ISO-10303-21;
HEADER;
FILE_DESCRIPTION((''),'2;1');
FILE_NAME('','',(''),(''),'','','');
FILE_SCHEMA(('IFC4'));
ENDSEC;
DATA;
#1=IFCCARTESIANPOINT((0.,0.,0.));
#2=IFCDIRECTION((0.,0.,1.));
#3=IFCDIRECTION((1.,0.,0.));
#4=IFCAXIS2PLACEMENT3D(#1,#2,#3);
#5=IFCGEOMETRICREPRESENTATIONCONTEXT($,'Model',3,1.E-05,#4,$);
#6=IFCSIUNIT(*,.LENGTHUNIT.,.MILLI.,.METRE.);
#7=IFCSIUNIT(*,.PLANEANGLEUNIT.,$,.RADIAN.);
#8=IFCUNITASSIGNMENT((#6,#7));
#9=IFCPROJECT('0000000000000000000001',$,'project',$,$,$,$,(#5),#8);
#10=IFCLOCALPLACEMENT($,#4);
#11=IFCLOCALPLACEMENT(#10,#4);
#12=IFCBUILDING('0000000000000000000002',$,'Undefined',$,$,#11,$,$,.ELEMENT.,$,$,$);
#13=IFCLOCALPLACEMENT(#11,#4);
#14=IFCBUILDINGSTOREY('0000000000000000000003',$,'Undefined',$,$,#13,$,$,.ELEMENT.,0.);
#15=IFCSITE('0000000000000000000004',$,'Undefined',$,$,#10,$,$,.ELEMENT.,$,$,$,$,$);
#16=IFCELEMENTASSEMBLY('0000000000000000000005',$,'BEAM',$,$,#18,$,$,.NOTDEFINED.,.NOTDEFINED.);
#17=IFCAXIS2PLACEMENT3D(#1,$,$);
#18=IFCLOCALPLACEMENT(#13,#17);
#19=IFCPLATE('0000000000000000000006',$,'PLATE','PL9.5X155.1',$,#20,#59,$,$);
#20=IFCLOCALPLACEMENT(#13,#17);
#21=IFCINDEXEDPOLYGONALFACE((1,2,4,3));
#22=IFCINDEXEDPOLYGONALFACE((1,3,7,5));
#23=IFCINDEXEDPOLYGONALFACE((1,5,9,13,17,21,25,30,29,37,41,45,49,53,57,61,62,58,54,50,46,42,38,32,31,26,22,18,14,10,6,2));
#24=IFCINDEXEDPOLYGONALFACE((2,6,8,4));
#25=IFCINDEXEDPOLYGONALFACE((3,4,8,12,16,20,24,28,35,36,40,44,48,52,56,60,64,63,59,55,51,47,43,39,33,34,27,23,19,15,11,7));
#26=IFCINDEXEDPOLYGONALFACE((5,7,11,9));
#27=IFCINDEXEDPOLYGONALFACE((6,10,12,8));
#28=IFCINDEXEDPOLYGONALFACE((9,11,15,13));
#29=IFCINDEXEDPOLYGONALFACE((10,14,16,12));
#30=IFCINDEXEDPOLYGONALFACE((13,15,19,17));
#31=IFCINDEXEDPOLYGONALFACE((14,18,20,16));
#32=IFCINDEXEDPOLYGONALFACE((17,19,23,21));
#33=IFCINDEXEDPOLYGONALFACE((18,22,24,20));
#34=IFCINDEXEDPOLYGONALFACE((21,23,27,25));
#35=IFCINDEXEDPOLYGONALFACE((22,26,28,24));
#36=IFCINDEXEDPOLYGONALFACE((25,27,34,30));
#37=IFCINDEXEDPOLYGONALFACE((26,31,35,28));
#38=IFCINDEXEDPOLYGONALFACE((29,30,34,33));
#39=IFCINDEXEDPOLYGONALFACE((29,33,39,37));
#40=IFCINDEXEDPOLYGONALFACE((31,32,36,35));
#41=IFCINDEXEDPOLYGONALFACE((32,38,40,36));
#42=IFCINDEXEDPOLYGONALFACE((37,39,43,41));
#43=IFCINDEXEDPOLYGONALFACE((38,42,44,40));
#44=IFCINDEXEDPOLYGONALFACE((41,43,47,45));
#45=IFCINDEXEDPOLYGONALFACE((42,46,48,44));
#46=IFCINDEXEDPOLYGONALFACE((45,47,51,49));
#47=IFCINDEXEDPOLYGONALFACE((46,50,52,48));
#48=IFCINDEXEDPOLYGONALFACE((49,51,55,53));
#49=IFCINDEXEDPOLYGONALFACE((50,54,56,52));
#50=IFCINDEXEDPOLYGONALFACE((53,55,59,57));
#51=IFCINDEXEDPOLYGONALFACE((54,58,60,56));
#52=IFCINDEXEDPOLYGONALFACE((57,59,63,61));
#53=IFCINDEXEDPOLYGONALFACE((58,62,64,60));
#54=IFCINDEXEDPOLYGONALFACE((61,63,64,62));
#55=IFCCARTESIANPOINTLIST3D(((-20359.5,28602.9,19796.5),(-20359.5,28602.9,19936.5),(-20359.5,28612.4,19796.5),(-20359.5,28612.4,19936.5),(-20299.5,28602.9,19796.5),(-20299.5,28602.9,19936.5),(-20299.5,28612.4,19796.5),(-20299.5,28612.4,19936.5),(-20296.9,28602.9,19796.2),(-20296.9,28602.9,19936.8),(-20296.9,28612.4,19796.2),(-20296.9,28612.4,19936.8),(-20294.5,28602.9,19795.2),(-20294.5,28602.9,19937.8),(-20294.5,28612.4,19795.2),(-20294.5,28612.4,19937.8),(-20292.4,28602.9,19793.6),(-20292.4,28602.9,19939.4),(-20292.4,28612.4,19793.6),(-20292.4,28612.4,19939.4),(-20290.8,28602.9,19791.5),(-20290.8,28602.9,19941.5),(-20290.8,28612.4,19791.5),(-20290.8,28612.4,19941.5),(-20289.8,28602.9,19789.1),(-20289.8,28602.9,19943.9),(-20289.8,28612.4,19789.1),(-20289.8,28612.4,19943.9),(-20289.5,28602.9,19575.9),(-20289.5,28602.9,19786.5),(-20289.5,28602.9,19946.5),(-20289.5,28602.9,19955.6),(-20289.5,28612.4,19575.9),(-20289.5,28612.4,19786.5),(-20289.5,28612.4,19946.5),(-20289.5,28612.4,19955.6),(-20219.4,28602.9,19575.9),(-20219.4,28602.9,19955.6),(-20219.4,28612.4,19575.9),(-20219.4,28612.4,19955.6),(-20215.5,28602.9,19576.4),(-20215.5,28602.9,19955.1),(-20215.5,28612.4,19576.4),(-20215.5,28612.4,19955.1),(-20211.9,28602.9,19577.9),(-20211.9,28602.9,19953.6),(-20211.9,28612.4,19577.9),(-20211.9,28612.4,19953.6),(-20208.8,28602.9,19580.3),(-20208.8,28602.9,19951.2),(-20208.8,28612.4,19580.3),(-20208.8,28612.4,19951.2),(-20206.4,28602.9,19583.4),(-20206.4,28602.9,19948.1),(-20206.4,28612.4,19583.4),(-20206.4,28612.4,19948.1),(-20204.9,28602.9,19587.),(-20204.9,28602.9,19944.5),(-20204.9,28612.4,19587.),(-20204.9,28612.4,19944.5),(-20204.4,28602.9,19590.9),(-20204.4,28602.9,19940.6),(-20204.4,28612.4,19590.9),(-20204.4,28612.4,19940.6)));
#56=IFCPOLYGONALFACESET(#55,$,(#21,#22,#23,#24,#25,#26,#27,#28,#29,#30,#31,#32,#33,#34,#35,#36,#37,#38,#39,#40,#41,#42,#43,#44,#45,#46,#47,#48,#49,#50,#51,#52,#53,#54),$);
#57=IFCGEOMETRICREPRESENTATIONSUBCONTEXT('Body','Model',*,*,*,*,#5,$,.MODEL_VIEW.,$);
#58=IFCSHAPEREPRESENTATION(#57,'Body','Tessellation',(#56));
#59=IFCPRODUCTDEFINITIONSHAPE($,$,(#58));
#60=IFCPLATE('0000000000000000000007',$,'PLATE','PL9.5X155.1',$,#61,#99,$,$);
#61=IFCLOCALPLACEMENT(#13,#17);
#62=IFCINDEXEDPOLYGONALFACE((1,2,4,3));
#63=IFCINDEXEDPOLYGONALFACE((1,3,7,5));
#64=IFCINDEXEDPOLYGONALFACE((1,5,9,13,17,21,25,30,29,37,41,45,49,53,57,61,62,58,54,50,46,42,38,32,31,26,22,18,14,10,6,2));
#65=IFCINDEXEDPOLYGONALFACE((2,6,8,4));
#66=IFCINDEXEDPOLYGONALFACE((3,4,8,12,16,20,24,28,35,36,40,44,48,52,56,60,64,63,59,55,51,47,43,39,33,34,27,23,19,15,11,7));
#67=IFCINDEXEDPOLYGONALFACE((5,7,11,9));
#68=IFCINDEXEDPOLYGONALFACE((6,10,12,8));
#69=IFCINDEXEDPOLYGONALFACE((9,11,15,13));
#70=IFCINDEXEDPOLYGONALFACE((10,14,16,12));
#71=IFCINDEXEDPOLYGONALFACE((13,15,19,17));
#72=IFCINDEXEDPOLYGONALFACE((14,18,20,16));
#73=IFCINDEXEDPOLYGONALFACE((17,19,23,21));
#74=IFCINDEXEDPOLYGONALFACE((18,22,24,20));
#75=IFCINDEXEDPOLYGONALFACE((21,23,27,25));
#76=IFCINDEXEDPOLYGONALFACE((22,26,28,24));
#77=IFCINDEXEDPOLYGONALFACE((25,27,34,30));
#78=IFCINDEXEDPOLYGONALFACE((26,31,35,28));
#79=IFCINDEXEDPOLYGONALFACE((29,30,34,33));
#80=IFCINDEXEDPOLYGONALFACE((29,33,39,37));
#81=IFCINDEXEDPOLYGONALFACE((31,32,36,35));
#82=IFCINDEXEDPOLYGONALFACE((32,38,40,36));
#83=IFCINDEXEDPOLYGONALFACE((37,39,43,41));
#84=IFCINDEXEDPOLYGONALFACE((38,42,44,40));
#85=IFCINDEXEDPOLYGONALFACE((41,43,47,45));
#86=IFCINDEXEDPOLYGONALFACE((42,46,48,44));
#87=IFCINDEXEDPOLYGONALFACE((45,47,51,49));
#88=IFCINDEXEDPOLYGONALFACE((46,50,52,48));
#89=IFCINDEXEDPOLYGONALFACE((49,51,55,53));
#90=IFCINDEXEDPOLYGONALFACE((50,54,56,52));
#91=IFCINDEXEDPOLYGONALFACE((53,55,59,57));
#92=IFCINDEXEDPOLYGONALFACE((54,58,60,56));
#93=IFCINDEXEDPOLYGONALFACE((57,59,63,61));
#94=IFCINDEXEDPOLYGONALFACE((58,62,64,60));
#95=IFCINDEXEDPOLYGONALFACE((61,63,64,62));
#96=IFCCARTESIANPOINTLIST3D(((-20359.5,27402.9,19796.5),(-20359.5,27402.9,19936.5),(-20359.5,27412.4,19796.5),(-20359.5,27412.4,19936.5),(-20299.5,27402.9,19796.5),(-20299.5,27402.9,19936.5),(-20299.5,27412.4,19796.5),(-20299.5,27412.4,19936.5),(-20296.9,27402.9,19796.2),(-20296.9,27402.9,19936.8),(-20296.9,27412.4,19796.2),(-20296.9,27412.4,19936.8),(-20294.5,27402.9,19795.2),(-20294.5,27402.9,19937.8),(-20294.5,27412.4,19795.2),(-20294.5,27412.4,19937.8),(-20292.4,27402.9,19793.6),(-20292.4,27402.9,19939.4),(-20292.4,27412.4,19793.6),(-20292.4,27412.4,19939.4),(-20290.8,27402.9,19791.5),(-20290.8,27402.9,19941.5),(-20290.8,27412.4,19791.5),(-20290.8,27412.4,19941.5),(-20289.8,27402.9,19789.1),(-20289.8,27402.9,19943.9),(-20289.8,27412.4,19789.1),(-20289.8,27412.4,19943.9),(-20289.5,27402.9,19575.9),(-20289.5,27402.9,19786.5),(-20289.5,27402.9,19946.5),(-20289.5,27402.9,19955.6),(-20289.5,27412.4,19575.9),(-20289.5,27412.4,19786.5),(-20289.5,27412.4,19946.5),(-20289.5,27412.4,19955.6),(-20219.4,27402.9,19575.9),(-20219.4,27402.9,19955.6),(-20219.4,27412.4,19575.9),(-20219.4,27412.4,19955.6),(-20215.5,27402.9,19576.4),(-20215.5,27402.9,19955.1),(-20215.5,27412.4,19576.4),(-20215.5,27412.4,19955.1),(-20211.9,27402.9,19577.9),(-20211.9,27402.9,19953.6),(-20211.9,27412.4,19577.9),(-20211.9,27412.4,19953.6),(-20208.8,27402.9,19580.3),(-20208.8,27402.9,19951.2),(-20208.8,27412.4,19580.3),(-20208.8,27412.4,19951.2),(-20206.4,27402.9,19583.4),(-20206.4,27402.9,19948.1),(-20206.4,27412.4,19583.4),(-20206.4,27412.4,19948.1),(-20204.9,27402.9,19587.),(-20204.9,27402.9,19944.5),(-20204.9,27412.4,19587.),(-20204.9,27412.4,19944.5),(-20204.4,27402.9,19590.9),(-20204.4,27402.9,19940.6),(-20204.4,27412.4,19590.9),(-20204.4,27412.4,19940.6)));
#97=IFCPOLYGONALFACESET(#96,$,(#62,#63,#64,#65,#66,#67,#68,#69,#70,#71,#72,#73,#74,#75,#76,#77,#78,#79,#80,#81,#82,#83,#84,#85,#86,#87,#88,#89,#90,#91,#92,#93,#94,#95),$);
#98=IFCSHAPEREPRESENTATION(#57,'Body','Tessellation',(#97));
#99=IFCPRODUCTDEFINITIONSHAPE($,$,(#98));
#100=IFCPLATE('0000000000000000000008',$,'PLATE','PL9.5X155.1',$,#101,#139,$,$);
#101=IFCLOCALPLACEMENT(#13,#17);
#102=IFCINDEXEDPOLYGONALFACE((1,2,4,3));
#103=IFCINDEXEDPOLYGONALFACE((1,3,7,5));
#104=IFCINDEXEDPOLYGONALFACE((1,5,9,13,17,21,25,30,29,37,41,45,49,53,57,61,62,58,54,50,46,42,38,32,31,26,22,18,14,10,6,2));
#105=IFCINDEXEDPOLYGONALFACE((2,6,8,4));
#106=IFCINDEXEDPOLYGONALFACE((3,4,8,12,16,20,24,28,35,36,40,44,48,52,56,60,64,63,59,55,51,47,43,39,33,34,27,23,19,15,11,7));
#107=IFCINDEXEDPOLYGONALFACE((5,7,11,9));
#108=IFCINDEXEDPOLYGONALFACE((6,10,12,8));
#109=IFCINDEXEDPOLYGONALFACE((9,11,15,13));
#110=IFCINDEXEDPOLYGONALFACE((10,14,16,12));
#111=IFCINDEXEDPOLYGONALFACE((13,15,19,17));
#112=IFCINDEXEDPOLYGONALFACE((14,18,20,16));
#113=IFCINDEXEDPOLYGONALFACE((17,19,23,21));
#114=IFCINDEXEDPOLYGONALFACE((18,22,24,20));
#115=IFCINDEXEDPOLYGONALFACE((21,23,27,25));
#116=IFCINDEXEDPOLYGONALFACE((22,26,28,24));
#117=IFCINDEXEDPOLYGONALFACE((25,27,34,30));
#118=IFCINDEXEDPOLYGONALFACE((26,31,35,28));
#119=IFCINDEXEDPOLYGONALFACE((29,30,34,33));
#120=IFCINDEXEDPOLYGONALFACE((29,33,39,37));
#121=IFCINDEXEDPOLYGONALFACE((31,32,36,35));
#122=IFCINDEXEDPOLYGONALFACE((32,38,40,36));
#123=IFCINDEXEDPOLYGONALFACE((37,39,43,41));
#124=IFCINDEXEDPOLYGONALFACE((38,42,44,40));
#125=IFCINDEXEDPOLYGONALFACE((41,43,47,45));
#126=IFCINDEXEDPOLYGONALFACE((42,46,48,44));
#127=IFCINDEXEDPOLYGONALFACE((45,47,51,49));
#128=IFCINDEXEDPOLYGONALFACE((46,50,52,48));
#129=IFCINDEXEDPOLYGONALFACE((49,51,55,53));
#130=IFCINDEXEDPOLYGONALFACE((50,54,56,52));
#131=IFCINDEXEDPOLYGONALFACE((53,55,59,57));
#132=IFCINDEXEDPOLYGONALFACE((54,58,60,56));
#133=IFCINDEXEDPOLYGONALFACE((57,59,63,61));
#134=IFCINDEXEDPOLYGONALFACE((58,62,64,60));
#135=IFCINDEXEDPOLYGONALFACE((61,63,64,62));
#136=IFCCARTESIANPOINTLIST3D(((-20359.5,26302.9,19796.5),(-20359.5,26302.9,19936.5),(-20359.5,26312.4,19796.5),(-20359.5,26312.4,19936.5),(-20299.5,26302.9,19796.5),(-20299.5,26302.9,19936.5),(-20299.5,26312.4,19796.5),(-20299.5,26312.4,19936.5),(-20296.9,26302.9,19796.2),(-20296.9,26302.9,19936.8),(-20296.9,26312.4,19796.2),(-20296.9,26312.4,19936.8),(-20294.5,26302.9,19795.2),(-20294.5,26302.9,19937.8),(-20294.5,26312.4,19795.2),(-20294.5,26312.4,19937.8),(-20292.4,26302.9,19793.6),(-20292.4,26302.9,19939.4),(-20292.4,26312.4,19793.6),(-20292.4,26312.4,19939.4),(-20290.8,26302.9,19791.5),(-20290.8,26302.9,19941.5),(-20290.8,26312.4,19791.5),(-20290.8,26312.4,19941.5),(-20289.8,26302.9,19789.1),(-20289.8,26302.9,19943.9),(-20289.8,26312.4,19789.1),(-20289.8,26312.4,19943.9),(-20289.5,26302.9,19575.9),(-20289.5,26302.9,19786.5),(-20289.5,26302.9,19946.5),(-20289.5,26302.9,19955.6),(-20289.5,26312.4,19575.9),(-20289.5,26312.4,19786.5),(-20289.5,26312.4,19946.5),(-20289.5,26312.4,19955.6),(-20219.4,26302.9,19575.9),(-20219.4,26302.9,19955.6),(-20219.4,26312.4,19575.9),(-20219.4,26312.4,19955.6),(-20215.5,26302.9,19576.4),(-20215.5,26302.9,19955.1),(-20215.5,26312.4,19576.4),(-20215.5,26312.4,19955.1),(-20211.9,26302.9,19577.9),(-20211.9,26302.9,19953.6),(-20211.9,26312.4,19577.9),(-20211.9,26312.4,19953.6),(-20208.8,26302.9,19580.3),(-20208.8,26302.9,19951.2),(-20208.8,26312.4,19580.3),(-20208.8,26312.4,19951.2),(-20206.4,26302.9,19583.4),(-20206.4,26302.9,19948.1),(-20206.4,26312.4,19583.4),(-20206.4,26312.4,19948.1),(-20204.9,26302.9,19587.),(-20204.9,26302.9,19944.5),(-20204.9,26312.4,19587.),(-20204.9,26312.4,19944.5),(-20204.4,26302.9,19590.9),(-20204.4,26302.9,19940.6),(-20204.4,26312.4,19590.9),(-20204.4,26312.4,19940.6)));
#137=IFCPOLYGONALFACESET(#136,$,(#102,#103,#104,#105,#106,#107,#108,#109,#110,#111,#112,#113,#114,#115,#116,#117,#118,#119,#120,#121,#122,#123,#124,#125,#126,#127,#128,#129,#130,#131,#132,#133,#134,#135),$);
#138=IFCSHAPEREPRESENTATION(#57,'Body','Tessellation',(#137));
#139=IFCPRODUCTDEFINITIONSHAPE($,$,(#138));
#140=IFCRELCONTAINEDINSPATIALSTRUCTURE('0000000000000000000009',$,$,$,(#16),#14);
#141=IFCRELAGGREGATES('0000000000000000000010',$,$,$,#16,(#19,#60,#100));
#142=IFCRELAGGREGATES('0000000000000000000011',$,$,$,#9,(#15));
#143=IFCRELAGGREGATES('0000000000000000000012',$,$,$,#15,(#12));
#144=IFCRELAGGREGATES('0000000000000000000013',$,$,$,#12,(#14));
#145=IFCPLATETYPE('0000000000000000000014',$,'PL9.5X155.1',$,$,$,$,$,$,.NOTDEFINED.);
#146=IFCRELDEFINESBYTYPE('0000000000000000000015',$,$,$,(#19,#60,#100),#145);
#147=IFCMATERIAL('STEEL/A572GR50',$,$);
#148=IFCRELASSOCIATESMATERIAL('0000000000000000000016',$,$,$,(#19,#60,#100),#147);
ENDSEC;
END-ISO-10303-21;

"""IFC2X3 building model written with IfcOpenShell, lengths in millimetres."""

from ifc_helpers import new_model, si_unit, frame, frame_2d, origin_with_axes, place, context, subcontext, project, spatial, polyline, circle_curve, parameter, trimmed, segment, composite_curve, outline, extrude, material, type_object, element, aggregate, save


model = new_model("IFC2X3")

# Units and contexts
model_context = context("Model", 3, precision=1e-05, world=origin_with_axes())
body_context = subcontext(model_context, "Body", "Model", "MODEL_VIEW")
ifc_project = project(units=[si_unit("LENGTHUNIT", "METRE", prefix="MILLI"), si_unit("PLANEANGLEUNIT", "RADIAN")], contexts=[model_context])

# Site, building, storey
site_placement = place(None, origin_with_axes())
site = spatial("IfcSite", under=ifc_project, at=site_placement, Name="Undefined", CompositionType="ELEMENT")
building_placement = place(site_placement, origin_with_axes())
building = spatial("IfcBuilding", under=site, at=building_placement, Name="Undefined", CompositionType="ELEMENT")
storey_placement = place(building_placement, origin_with_axes())
storey = spatial("IfcBuildingStorey", under=building, at=storey_placement, Name="Undefined", CompositionType="ELEMENT", Elevation=0.0)

# Element assembly
assembly_1_placement = place(storey_placement, origin_with_axes())
assembly_1 = element("IfcElementAssembly", 1, at=assembly_1_placement, inside=storey, Name="BEAM", AssemblyPlace="NOTDEFINED", PredefinedType="NOTDEFINED")
ifc_material_1 = material(Name="STEEL/A572GR50")

# Plates
plate_type_1 = type_object("IfcPlateType", Name="PL9.5X155.1", PredefinedType="NOTDEFINED")
plate_1_placement = place(assembly_1_placement, frame((-20204.4, 28607.7, 19955.6), z_axis=(0.0, 1.0, 0.0), x_axis=(0.0, 0.0, -1.0)))
plate_1 = element("IfcPlate", 2, at=plate_1_placement, type_object=plate_type_1, material=ifc_material_1, Name="PLATE", Description="PL9.5X155.1", context=body_context, shape_type="SweptSolid", body=[
    extrude(outline(composite_curve([segment(trimmed(circle_curve(frame_2d((15.0, 15.0), x_axis=(-1.0, 0.0)), 15.0), [parameter(0.0)], [parameter(1.570796)], True, "PARAMETER"), True, "CONTINUOUS"), segment(polyline([(15.0, 0.0), (364.7, 0.0)]), True, "CONTINUOUS"), segment(trimmed(circle_curve(frame_2d((364.7, 15.0), x_axis=(0.0, -1.0)), 15.0), [parameter(0.0)], [parameter(1.570796)], True, "PARAMETER"), True, "CONTINUOUS"), segment(polyline([(379.7, 15.0), (379.7, 85.1), (169.1, 85.1)]), True, "CONTINUOUS"), segment(trimmed(circle_curve(frame_2d((169.1, 95.1), x_axis=(0.0, -1.0)), 10.0), [parameter(0.0)], [parameter(4.712389)], False, "PARAMETER"), True, "CONTINUOUS"), segment(polyline([(159.1, 95.1), (159.1, 155.1), (19.1, 155.1), (19.1, 95.1)]), True, "CONTINUOUS"), segment(trimmed(circle_curve(frame_2d((9.1, 95.1), x_axis=(1.0, 0.0)), 10.0), [parameter(0.0)], [parameter(4.712389)], False, "PARAMETER"), True, "CONTINUOUS"), segment(polyline([(9.1, 85.1), (0.0, 85.1), (0.0, 15.0)]), True, "CONTINUOUS")], self_intersect=True)), frame((0.0, 0.0, -4.8), z_axis=(0.0, 0.0, 1.0), x_axis=(1.0, 0.0, 0.0)), (0.0, 0.0, 1.0), 9.5),
])
plate_2_placement = place(assembly_1_placement, frame((-20204.4, 27407.7, 19955.6), z_axis=(0.0, 1.0, 0.0), x_axis=(0.0, 0.0, -1.0)))
plate_2 = element("IfcPlate", 3, at=plate_2_placement, type_object=plate_type_1, material=ifc_material_1, Name="PLATE", Description="PL9.5X155.1", context=body_context, shape_type="SweptSolid", body=[
    extrude(outline(composite_curve([segment(trimmed(circle_curve(frame_2d((15.0, 15.0), x_axis=(-1.0, 0.0)), 15.0), [parameter(0.0)], [parameter(1.570796)], True, "PARAMETER"), True, "CONTINUOUS"), segment(polyline([(15.0, 0.0), (364.7, 0.0)]), True, "CONTINUOUS"), segment(trimmed(circle_curve(frame_2d((364.7, 15.0), x_axis=(0.0, -1.0)), 15.0), [parameter(0.0)], [parameter(1.570796)], True, "PARAMETER"), True, "CONTINUOUS"), segment(polyline([(379.7, 15.0), (379.7, 85.1), (169.1, 85.1)]), True, "CONTINUOUS"), segment(trimmed(circle_curve(frame_2d((169.1, 95.1), x_axis=(0.0, -1.0)), 10.0), [parameter(0.0)], [parameter(4.712389)], False, "PARAMETER"), True, "CONTINUOUS"), segment(polyline([(159.1, 95.1), (159.1, 155.1), (19.1, 155.1), (19.1, 95.1)]), True, "CONTINUOUS"), segment(trimmed(circle_curve(frame_2d((9.1, 95.1), x_axis=(1.0, 0.0)), 10.0), [parameter(0.0)], [parameter(4.712389)], False, "PARAMETER"), True, "CONTINUOUS"), segment(polyline([(9.1, 85.1), (0.0, 85.1), (0.0, 15.0)]), True, "CONTINUOUS")], self_intersect=True)), frame((0.0, 0.0, -4.8), z_axis=(0.0, 0.0, 1.0), x_axis=(1.0, 0.0, 0.0)), (0.0, 0.0, 1.0), 9.5),
])
plate_3_placement = place(assembly_1_placement, frame((-20204.4, 26307.7, 19955.6), z_axis=(0.0, 1.0, 0.0), x_axis=(0.0, 0.0, -1.0)))
plate_3 = element("IfcPlate", 4, at=plate_3_placement, type_object=plate_type_1, material=ifc_material_1, Name="PLATE", Description="PL9.5X155.1", context=body_context, shape_type="SweptSolid", body=[
    extrude(outline(composite_curve([segment(trimmed(circle_curve(frame_2d((15.0, 15.0), x_axis=(-1.0, 0.0)), 15.0), [parameter(0.0)], [parameter(1.570796)], True, "PARAMETER"), True, "CONTINUOUS"), segment(polyline([(15.0, 0.0), (364.7, 0.0)]), True, "CONTINUOUS"), segment(trimmed(circle_curve(frame_2d((364.7, 15.0), x_axis=(0.0, -1.0)), 15.0), [parameter(0.0)], [parameter(1.570796)], True, "PARAMETER"), True, "CONTINUOUS"), segment(polyline([(379.7, 15.0), (379.7, 85.1), (169.1, 85.1)]), True, "CONTINUOUS"), segment(trimmed(circle_curve(frame_2d((169.1, 95.1), x_axis=(0.0, -1.0)), 10.0), [parameter(0.0)], [parameter(4.712389)], False, "PARAMETER"), True, "CONTINUOUS"), segment(polyline([(159.1, 95.1), (159.1, 155.1), (19.1, 155.1), (19.1, 95.1)]), True, "CONTINUOUS"), segment(trimmed(circle_curve(frame_2d((9.1, 95.1), x_axis=(1.0, 0.0)), 10.0), [parameter(0.0)], [parameter(4.712389)], False, "PARAMETER"), True, "CONTINUOUS"), segment(polyline([(9.1, 85.1), (0.0, 85.1), (0.0, 15.0)]), True, "CONTINUOUS")], self_intersect=True)), frame((0.0, 0.0, -4.8), z_axis=(0.0, 0.0, 1.0), x_axis=(1.0, 0.0, 0.0)), (0.0, 0.0, 1.0), 9.5),
])

aggregate(assembly_1, [plate_1, plate_2, plate_3])

save(model, "model.ifc")
